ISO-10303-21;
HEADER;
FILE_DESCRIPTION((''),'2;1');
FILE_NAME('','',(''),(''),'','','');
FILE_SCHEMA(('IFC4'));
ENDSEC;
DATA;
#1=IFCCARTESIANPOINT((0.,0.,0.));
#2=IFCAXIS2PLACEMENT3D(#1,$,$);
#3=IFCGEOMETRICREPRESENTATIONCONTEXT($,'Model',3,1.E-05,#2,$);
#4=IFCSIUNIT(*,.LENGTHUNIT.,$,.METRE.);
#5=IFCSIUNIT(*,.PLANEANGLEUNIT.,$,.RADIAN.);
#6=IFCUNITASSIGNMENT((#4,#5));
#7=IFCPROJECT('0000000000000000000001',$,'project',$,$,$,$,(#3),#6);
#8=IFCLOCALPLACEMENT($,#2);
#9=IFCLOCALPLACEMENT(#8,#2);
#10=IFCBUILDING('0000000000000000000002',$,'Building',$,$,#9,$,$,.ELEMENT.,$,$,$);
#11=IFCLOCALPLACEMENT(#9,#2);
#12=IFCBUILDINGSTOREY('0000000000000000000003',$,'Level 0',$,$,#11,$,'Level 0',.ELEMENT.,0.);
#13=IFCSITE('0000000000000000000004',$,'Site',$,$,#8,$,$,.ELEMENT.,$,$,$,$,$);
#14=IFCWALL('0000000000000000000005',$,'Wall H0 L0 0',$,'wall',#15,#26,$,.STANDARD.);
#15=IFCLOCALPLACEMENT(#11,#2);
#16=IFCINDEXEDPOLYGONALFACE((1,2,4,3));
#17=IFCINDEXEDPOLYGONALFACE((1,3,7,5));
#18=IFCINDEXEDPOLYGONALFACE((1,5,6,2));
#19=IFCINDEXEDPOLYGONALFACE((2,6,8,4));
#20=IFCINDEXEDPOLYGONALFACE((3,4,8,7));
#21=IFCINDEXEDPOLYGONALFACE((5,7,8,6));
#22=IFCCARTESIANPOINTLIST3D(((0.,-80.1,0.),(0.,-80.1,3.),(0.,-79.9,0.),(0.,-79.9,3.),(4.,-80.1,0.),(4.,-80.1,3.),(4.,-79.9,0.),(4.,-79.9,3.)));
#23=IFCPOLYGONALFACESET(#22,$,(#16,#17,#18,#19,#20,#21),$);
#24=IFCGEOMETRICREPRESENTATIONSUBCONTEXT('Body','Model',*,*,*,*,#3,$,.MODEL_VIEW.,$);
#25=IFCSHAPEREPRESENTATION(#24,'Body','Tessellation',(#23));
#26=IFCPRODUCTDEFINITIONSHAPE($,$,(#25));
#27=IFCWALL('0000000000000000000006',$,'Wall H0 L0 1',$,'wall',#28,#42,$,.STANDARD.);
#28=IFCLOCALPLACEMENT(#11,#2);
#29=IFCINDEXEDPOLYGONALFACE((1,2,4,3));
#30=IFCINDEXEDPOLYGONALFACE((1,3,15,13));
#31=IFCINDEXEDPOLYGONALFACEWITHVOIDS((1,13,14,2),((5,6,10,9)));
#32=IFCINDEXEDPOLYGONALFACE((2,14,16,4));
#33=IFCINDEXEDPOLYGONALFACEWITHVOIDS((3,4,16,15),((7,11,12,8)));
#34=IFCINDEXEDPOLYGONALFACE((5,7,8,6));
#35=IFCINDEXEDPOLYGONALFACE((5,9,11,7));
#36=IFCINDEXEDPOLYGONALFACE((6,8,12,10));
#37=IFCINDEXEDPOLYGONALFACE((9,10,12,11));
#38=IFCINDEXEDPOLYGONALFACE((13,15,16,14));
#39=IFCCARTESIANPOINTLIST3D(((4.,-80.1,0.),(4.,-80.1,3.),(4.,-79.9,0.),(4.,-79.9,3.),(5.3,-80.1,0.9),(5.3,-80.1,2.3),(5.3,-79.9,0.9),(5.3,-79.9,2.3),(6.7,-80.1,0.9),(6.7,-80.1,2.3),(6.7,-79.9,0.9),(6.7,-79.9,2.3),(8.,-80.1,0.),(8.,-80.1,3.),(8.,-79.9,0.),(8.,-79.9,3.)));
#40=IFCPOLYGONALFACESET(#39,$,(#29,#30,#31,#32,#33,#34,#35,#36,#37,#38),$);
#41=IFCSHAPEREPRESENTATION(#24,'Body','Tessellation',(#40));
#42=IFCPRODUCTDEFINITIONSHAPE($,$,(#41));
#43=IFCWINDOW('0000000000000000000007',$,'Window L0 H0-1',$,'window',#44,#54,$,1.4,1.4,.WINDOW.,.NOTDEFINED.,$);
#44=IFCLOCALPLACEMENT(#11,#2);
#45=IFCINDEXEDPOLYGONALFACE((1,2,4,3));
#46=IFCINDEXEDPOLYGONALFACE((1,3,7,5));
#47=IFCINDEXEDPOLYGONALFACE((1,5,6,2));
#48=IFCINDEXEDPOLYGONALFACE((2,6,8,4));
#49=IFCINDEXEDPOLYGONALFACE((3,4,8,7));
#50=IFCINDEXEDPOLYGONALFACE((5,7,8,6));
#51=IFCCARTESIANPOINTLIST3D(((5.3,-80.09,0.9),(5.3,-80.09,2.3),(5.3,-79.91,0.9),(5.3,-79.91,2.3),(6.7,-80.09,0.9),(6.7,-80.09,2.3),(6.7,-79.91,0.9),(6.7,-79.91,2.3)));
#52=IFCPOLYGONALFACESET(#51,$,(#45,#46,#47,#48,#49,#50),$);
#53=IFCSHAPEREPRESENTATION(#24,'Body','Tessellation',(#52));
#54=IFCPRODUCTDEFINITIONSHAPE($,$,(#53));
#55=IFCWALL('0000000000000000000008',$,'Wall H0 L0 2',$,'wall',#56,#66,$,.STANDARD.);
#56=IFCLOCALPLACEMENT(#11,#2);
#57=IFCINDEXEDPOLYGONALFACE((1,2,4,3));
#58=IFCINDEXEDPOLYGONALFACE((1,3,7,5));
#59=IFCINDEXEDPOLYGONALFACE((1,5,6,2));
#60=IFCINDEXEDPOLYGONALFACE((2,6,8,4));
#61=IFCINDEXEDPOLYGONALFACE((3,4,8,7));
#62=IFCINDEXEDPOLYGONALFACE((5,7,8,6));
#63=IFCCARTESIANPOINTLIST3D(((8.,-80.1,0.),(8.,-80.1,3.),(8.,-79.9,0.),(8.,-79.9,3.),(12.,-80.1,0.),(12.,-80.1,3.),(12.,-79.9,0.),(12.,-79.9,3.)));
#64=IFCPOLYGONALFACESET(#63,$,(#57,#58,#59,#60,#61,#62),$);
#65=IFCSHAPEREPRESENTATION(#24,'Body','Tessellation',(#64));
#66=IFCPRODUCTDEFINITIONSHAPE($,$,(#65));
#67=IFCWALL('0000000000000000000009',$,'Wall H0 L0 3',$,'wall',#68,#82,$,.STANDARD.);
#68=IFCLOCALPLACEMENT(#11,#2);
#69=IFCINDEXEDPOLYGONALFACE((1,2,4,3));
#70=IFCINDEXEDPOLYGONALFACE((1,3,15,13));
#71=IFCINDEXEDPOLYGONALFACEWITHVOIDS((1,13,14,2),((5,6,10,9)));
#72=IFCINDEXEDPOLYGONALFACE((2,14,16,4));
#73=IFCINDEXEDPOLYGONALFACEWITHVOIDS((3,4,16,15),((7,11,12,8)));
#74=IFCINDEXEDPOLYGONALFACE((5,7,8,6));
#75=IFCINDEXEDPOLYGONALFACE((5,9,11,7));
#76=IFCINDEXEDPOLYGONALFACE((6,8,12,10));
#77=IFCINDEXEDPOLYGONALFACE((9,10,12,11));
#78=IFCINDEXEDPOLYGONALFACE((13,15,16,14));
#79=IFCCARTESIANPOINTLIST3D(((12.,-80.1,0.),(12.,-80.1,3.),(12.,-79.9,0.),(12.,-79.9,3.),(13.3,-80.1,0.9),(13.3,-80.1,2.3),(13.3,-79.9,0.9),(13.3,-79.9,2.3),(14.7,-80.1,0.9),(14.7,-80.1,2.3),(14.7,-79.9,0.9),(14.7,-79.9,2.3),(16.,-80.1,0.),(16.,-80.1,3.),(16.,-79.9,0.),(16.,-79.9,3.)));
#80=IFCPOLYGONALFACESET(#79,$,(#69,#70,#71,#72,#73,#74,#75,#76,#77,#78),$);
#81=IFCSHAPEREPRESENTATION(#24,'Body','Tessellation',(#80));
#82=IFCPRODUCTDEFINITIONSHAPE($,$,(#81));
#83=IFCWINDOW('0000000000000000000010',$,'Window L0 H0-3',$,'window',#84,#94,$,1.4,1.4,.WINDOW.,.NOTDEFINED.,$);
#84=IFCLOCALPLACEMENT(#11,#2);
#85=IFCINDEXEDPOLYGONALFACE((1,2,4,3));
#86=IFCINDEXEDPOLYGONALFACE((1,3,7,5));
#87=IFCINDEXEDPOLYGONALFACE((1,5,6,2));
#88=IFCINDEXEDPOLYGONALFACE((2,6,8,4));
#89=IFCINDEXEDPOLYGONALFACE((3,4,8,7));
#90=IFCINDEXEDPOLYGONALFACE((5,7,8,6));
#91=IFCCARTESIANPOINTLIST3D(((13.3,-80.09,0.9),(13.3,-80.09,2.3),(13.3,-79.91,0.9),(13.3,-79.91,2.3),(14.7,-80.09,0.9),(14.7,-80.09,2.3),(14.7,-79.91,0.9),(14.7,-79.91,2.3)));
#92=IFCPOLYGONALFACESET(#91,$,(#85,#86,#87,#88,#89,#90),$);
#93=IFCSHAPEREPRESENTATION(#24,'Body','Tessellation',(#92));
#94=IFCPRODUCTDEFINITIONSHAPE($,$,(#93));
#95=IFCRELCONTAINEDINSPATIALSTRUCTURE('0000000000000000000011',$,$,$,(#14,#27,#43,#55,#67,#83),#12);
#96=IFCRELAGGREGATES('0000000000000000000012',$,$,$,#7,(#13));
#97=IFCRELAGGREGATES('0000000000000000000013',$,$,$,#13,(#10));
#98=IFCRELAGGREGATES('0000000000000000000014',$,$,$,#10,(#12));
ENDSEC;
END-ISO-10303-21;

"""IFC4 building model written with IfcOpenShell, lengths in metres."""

from ifc_helpers import new_model, si_unit, frame, frame_2d, origin, origin_2d, place, context, subcontext, project, spatial, rectangle, extrude, element, fill, save


model = new_model("IFC4")

# Units and contexts
model_context = context("Model", 3, precision=1e-05, world=origin())
body_context = subcontext(model_context, "Body", "Model", "MODEL_VIEW")
ifc_project = project(units=[si_unit("LENGTHUNIT", "METRE"), si_unit("PLANEANGLEUNIT", "RADIAN")], contexts=[model_context])

# Site, building, storey
site_placement = place(None, origin())
site = spatial("IfcSite", under=ifc_project, at=site_placement, Name="Site", CompositionType="ELEMENT")
building_placement = place(site_placement, origin())
building = spatial("IfcBuilding", under=site, at=building_placement, Name="Building", CompositionType="ELEMENT")
storey_placement = place(building_placement, origin())
storey = spatial("IfcBuildingStorey", under=building, at=storey_placement, Name="Level 0", LongName="Level 0", CompositionType="ELEMENT", Elevation=0.0)

# Wall
wall_1_placement = place(storey_placement, frame((0.0, -80.0, 0.0), z_axis=(0.0, 0.0, 1.0), x_axis=(1.0, 0.0, 0.0)))
element("IfcWall", 1, at=wall_1_placement, inside=storey, Name="Wall H0 L0 0", ObjectType="wall", PredefinedType="STANDARD", context=body_context, shape_type="SweptSolid", body=[
    extrude(rectangle(XDim=4.0, YDim=0.2, at=frame_2d((2.0, 0.0))), origin(), (0.0, 0.0, 1.0), 3.0),
])

# Wall, opening, window
wall_2_placement = place(storey_placement, frame((4.0, -80.0, 0.0), z_axis=(0.0, 0.0, 1.0), x_axis=(1.0, 0.0, 0.0)))
wall_2 = element("IfcWall", 2, at=wall_2_placement, inside=storey, Name="Wall H0 L0 1", ObjectType="wall", PredefinedType="STANDARD", context=body_context, shape_type="SweptSolid", body=[
    extrude(rectangle(XDim=4.0, YDim=0.2, at=frame_2d((2.0, 0.0))), origin(), (0.0, 0.0, 1.0), 3.0),
])
opening_1_placement = place(storey_placement, frame((6.0, -80.0, 0.9), z_axis=(0.0, 0.0, 1.0), x_axis=(1.0, 0.0, 0.0)))
opening_1 = element("IfcOpeningElement", 3, at=opening_1_placement, cuts=wall_2, ObjectType="Opening", PredefinedType="OPENING", context=body_context, shape_type="SweptSolid", body=[
    extrude(rectangle(XDim=1.4, YDim=0.22, at=origin_2d()), origin(), (0.0, 0.0, 1.0), 1.4),
])
window_1_placement = place(storey_placement, frame((6.0, -80.0, 0.9), z_axis=(0.0, 0.0, 1.0), x_axis=(1.0, 0.0, 0.0)))
window_1 = element("IfcWindow", 4, at=window_1_placement, inside=storey, Name="Window L0 H0-1", ObjectType="window", OverallHeight=1.4, OverallWidth=1.4, PartitioningType="NOTDEFINED", PredefinedType="WINDOW", context=body_context, shape_type="SweptSolid", body=[
    extrude(rectangle(XDim=1.4, YDim=0.18, at=origin_2d()), origin(), (0.0, 0.0, 1.0), 1.4),
])
fill(opening_1, window_1)

# Wall
wall_3_placement = place(storey_placement, frame((8.0, -80.0, 0.0), z_axis=(0.0, 0.0, 1.0), x_axis=(1.0, 0.0, 0.0)))
element("IfcWall", 5, at=wall_3_placement, inside=storey, Name="Wall H0 L0 2", ObjectType="wall", PredefinedType="STANDARD", context=body_context, shape_type="SweptSolid", body=[
    extrude(rectangle(XDim=4.0, YDim=0.2, at=frame_2d((2.0, 0.0))), origin(), (0.0, 0.0, 1.0), 3.0),
])

# Wall, opening, window
wall_4_placement = place(storey_placement, frame((12.0, -80.0, 0.0), z_axis=(0.0, 0.0, 1.0), x_axis=(1.0, 0.0, 0.0)))
wall_4 = element("IfcWall", 6, at=wall_4_placement, inside=storey, Name="Wall H0 L0 3", ObjectType="wall", PredefinedType="STANDARD", context=body_context, shape_type="SweptSolid", body=[
    extrude(rectangle(XDim=4.0, YDim=0.2, at=frame_2d((2.0, 0.0))), origin(), (0.0, 0.0, 1.0), 3.0),
])
opening_2_placement = place(storey_placement, frame((14.0, -80.0, 0.9), z_axis=(0.0, 0.0, 1.0), x_axis=(1.0, 0.0, 0.0)))
opening_2 = element("IfcOpeningElement", 7, at=opening_2_placement, cuts=wall_4, ObjectType="Opening", PredefinedType="OPENING", context=body_context, shape_type="SweptSolid", body=[
    extrude(rectangle(XDim=1.4, YDim=0.22, at=origin_2d()), origin(), (0.0, 0.0, 1.0), 1.4),
])
window_2_placement = place(storey_placement, frame((14.0, -80.0, 0.9), z_axis=(0.0, 0.0, 1.0), x_axis=(1.0, 0.0, 0.0)))
window_2 = element("IfcWindow", 8, at=window_2_placement, inside=storey, Name="Window L0 H0-3", ObjectType="window", OverallHeight=1.4, OverallWidth=1.4, PartitioningType="NOTDEFINED", PredefinedType="WINDOW", context=body_context, shape_type="SweptSolid", body=[
    extrude(rectangle(XDim=1.4, YDim=0.18, at=origin_2d()), origin(), (0.0, 0.0, 1.0), 1.4),
])
fill(opening_2, window_2)

save(model, "model.ifc")
